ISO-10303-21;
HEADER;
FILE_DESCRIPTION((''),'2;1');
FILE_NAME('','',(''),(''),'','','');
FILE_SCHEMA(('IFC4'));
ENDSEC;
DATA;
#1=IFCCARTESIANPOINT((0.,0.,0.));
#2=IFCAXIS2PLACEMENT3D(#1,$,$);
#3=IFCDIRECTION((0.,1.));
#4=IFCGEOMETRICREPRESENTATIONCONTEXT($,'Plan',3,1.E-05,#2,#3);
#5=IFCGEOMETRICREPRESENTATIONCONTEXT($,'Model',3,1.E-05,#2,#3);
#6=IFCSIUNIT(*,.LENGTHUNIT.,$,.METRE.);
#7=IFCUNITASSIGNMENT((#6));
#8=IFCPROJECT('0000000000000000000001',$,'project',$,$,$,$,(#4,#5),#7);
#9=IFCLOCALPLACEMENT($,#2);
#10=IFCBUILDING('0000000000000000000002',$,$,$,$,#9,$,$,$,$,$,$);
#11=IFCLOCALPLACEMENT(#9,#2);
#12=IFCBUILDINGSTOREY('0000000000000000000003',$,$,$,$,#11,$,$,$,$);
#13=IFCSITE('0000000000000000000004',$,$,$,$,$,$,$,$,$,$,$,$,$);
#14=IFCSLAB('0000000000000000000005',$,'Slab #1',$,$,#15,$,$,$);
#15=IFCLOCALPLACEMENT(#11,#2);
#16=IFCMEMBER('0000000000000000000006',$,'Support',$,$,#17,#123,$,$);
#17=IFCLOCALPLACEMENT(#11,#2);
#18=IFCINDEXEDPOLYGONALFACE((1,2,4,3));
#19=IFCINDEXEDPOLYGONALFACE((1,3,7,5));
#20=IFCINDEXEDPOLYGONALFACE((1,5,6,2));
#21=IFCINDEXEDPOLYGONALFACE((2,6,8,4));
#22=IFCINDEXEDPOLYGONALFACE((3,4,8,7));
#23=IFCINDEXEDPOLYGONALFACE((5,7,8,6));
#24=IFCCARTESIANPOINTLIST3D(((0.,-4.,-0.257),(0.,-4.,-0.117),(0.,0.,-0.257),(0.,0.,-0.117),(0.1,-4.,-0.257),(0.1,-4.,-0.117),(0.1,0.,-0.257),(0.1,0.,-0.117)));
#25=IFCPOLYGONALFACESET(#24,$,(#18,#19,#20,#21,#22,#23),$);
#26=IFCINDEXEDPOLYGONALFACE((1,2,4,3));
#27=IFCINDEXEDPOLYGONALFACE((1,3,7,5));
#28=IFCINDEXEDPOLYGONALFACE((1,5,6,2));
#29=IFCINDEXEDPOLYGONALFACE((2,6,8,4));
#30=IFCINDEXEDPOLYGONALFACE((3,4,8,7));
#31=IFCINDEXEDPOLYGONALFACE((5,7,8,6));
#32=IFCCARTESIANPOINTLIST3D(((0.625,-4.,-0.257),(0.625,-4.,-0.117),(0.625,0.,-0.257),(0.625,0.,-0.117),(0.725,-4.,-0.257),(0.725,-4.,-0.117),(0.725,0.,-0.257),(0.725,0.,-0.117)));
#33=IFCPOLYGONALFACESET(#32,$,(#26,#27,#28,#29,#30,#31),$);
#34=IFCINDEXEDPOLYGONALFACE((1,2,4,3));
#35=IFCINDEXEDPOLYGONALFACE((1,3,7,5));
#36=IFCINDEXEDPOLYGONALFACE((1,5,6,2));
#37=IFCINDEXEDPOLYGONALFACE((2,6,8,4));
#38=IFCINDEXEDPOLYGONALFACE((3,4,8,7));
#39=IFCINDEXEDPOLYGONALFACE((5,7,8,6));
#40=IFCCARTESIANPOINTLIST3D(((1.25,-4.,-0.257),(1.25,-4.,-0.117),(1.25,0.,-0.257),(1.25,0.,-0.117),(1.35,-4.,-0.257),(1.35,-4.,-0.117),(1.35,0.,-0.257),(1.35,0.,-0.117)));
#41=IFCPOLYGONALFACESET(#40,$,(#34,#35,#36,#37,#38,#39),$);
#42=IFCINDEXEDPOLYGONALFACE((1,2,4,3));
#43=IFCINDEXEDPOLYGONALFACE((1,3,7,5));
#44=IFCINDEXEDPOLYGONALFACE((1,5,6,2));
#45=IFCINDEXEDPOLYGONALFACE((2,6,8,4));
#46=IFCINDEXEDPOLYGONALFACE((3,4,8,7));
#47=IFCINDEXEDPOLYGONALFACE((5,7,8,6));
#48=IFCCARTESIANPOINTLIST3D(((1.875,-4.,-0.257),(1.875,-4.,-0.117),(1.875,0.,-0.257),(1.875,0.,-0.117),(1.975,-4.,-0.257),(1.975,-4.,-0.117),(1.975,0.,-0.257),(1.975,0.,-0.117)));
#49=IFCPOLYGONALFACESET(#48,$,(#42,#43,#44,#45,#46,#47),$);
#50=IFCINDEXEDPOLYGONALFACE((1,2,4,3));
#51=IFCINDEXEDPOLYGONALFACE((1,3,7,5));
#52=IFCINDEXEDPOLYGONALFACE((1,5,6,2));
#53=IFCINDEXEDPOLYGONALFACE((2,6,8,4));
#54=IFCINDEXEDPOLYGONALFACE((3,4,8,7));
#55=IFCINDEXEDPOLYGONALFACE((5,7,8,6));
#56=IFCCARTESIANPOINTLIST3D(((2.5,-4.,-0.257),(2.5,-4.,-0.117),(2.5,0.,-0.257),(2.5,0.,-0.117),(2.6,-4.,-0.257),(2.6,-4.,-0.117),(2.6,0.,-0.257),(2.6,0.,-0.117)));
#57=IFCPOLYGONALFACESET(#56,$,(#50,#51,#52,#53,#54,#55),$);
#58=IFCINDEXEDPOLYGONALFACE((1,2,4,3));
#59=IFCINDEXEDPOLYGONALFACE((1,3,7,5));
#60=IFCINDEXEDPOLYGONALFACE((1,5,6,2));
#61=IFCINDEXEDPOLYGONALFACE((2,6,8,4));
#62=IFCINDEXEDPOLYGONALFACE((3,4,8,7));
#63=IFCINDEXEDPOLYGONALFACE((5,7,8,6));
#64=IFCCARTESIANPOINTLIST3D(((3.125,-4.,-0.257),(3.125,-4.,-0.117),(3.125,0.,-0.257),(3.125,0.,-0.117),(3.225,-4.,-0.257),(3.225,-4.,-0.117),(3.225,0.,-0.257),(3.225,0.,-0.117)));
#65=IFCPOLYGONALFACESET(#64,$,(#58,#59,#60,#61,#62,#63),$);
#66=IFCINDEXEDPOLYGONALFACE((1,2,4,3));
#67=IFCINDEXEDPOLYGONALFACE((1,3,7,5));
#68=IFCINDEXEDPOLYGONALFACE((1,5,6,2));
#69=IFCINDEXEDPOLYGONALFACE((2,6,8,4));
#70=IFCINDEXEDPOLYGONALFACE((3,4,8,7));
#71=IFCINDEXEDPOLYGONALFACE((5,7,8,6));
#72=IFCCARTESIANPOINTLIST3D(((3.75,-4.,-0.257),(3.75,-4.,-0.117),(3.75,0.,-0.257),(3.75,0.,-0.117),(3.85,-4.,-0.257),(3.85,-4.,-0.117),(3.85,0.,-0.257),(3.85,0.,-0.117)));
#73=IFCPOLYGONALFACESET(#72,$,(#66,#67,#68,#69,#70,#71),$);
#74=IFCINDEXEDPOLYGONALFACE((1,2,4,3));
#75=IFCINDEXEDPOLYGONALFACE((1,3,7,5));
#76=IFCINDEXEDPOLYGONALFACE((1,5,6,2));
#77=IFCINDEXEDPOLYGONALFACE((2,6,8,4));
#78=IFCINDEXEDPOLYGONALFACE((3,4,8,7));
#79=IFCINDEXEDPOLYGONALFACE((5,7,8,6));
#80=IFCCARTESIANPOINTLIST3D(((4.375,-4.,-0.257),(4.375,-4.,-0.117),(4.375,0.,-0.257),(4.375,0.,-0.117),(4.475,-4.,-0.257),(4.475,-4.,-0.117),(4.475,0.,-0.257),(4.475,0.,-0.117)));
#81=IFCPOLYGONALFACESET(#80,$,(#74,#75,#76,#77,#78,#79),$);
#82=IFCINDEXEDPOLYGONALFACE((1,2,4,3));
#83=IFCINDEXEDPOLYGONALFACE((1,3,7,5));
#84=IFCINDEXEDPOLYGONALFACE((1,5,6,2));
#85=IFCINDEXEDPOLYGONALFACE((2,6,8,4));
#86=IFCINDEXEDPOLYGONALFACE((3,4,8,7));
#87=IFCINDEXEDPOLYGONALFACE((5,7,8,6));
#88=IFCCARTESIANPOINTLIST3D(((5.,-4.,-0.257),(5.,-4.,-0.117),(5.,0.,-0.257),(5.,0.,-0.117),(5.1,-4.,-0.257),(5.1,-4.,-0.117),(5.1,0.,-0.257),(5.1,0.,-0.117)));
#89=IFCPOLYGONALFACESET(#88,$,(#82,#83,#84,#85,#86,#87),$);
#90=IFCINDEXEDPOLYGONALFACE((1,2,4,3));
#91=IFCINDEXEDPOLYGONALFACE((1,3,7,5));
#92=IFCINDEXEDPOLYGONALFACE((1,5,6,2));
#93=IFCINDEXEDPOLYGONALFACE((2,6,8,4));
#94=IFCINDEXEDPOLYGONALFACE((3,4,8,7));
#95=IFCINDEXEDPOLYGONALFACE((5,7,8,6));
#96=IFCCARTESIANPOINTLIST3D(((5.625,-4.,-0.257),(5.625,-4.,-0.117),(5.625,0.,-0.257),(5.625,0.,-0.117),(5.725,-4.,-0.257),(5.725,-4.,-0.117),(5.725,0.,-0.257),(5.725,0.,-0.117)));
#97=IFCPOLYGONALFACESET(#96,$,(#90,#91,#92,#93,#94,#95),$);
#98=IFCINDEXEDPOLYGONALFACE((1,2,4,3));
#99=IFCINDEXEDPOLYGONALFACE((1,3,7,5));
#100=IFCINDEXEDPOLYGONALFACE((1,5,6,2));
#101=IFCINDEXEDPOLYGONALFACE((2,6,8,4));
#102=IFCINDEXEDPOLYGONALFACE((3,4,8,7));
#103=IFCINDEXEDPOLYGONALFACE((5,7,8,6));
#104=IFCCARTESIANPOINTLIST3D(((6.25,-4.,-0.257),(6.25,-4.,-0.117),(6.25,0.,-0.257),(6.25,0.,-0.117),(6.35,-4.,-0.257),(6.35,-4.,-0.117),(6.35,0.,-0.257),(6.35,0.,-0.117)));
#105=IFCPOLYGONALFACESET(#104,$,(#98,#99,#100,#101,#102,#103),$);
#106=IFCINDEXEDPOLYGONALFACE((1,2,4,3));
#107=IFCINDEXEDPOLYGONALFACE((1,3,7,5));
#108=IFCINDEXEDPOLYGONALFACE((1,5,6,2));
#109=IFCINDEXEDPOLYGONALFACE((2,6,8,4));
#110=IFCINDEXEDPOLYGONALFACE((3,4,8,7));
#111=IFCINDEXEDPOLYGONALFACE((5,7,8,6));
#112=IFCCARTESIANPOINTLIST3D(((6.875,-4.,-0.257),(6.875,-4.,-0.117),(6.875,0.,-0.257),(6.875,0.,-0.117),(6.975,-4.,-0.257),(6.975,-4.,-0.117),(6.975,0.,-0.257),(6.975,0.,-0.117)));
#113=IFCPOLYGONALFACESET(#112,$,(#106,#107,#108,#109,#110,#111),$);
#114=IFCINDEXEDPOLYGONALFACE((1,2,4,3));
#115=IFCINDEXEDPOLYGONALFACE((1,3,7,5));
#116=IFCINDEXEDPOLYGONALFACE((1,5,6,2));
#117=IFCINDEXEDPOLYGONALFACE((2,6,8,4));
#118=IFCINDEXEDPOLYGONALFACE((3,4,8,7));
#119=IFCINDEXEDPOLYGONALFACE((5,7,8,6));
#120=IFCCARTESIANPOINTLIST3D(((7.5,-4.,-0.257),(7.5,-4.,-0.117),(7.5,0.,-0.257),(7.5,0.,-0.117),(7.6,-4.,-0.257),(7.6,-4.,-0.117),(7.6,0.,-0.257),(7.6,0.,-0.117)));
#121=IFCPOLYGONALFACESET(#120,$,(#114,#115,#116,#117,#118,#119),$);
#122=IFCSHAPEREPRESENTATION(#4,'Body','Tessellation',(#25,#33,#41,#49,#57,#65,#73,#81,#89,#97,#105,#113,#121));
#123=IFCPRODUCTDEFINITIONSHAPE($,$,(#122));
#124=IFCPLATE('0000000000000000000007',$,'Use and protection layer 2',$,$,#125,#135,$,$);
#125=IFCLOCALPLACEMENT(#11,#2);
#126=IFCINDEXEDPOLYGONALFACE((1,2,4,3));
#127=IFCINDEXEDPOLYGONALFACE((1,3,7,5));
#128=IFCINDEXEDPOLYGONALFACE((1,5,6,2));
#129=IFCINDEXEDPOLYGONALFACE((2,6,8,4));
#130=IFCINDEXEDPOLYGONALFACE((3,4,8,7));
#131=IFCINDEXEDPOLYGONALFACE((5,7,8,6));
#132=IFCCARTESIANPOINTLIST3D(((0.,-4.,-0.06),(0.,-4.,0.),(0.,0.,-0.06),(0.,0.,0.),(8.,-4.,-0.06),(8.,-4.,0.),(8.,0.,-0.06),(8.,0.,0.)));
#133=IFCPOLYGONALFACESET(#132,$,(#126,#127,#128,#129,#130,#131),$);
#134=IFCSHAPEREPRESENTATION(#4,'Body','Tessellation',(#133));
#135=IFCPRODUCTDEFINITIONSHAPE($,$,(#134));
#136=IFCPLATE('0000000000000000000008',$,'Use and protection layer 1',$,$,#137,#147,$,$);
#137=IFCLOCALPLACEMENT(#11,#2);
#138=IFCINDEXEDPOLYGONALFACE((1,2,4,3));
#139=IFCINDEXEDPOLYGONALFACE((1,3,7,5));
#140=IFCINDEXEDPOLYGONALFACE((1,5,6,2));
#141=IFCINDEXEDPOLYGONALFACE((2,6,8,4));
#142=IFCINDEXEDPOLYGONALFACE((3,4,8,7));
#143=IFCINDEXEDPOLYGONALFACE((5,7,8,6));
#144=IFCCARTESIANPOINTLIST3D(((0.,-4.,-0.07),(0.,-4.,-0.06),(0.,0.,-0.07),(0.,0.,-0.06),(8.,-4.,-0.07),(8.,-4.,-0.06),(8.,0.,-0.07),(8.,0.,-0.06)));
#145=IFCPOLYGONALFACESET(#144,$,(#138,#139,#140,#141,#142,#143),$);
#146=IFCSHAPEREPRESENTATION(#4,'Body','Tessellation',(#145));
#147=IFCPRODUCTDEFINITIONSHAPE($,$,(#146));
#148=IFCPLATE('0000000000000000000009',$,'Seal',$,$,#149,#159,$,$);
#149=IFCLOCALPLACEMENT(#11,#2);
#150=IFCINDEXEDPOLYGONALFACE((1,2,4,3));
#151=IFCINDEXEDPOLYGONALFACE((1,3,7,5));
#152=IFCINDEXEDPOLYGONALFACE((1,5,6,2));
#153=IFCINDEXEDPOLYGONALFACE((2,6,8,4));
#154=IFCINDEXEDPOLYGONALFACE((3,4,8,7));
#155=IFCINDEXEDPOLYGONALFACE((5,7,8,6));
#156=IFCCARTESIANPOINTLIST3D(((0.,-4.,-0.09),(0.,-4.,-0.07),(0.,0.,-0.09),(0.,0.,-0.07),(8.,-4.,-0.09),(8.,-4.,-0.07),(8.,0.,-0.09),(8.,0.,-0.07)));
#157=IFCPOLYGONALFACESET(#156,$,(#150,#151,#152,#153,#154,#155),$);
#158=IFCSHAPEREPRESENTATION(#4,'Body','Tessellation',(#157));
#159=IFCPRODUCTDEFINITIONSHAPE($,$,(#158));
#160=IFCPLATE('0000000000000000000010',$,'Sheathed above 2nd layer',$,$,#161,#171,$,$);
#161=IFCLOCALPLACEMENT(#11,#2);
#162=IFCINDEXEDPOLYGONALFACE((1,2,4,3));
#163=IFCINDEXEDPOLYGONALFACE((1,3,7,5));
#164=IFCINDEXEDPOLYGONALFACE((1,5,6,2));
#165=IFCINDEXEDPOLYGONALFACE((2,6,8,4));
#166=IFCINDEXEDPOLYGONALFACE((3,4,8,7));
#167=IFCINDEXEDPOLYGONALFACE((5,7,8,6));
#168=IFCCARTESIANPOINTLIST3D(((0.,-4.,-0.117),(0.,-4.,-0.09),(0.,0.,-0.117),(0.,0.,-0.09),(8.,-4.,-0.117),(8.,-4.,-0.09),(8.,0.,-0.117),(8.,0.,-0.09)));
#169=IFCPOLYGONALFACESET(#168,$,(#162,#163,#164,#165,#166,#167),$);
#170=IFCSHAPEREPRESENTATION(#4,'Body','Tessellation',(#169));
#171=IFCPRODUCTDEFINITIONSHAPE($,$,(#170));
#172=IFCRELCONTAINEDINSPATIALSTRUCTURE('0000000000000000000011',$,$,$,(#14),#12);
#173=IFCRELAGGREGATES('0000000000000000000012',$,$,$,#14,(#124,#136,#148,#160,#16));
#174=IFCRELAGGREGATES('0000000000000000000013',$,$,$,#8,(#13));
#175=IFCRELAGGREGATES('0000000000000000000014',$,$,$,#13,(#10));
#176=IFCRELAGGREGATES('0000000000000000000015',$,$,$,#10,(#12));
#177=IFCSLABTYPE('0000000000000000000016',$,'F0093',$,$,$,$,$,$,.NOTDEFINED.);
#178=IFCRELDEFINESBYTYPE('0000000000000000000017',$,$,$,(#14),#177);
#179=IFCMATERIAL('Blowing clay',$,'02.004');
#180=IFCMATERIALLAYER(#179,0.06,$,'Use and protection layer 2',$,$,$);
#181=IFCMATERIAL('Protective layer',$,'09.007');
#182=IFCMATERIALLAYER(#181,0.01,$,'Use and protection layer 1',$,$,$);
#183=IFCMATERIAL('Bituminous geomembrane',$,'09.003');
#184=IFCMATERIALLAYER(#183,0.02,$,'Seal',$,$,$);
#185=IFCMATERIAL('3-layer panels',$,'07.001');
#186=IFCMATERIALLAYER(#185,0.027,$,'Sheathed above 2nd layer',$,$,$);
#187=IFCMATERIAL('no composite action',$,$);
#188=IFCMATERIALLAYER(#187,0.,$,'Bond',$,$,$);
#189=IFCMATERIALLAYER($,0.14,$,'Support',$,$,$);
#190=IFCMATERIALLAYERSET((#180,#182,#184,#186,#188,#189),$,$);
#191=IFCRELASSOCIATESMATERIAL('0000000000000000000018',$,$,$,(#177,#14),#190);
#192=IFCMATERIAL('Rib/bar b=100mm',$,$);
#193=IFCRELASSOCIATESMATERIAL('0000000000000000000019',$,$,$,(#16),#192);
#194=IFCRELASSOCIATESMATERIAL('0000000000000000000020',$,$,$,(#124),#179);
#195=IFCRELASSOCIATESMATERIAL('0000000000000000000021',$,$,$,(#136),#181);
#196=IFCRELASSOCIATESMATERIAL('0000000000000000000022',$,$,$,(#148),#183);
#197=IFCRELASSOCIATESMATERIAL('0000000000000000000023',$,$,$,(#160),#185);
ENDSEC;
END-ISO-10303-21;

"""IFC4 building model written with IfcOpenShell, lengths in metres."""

from ifc_helpers import new_model, si_unit, direction, frame, frame_2d, origin, origin_with_axes, place, context, project, spatial, rectangle, extrude, material, layer, layer_set, type_object, element, aggregate, save


model = new_model("IFC4")

# Units and contexts
plan_context = context("Plan", 3, precision=1e-05, world=origin(), true_north=direction((0.0, 1.0)))
model_context = context("Model", 3, precision=1e-05, world=origin(), true_north=direction((0.0, 1.0)))
ifc_project = project(units=[si_unit("LENGTHUNIT", "METRE")], contexts=[plan_context, model_context])

# Site, building, storey
site = spatial("IfcSite", under=ifc_project)
building_placement = place(None, origin())
building = spatial("IfcBuilding", under=site, at=building_placement)
storey_placement = place(building_placement, origin())
storey = spatial("IfcBuildingStorey", under=building, at=storey_placement)

# Slab, member, plates
ifc_material_1 = material(Name="Blowing clay", Category="02.004")
ifc_layer_1 = layer(ifc_material_1, 0.06, Name="Use and protection layer 2")
ifc_material_2 = material(Name="Protective layer", Category="09.007")
ifc_layer_2 = layer(ifc_material_2, 0.01, Name="Use and protection layer 1")
ifc_material_3 = material(Name="Bituminous geomembrane", Category="09.003")
ifc_layer_3 = layer(ifc_material_3, 0.02, Name="Seal")
ifc_material_4 = material(Name="3-layer panels", Category="07.001")
ifc_layer_4 = layer(ifc_material_4, 0.027, Name="Sheathed above 2nd layer")
ifc_material_5 = material(Name="no composite action")
ifc_layer_5 = layer(ifc_material_5, 0.0, Name="Bond")
ifc_layer_6 = layer(None, 0.14, Name="Support")
ifc_layer_set = layer_set([ifc_layer_1, ifc_layer_2, ifc_layer_3, ifc_layer_4, ifc_layer_5, ifc_layer_6])
slab_type = type_object("IfcSlabType", Name="F0093", PredefinedType="NOTDEFINED", material=ifc_layer_set)
slab_placement = place(None, frame((0.0, 0.0, 0.0), z_axis=(0.0, 0.0, -1.0), x_axis=(1.0, 0.0, 0.0)))
slab = element("IfcSlab", 1, at=slab_placement, inside=storey, type_object=slab_type, material=ifc_layer_set, Name="Slab #1")
ifc_material_6 = material(Name="Rib/bar b=100mm")
member_placement = place(slab_placement, origin())
member = element("IfcMember", 2, at=member_placement, material=ifc_material_6, Name="Support", context=plan_context, shape_type="SweptSolid", body=[
    extrude(rectangle(XDim=0.1, YDim=0.14, at=frame_2d((0.05, 0.07), x_axis=(1.0, 0.0))), frame((0.0, 4.0, 0.117), z_axis=(0.0, -1.0, 0.0), x_axis=(1.0, 0.0, 0.0)), (0.0, 0.0, 1.0), 4.0),
    extrude(rectangle(XDim=0.1, YDim=0.14, at=frame_2d((0.05, 0.07), x_axis=(1.0, 0.0))), frame((0.625, 4.0, 0.117), z_axis=(0.0, -1.0, 0.0), x_axis=(1.0, 0.0, 0.0)), (0.0, 0.0, 1.0), 4.0),
    extrude(rectangle(XDim=0.1, YDim=0.14, at=frame_2d((0.05, 0.07), x_axis=(1.0, 0.0))), frame((1.25, 4.0, 0.117), z_axis=(0.0, -1.0, 0.0), x_axis=(1.0, 0.0, 0.0)), (0.0, 0.0, 1.0), 4.0),
    extrude(rectangle(XDim=0.1, YDim=0.14, at=frame_2d((0.05, 0.07), x_axis=(1.0, 0.0))), frame((1.875, 4.0, 0.117), z_axis=(0.0, -1.0, 0.0), x_axis=(1.0, 0.0, 0.0)), (0.0, 0.0, 1.0), 4.0),
    extrude(rectangle(XDim=0.1, YDim=0.14, at=frame_2d((0.05, 0.07), x_axis=(1.0, 0.0))), frame((2.5, 4.0, 0.117), z_axis=(0.0, -1.0, 0.0), x_axis=(1.0, 0.0, 0.0)), (0.0, 0.0, 1.0), 4.0),
    extrude(rectangle(XDim=0.1, YDim=0.14, at=frame_2d((0.05, 0.07), x_axis=(1.0, 0.0))), frame((3.125, 4.0, 0.117), z_axis=(0.0, -1.0, 0.0), x_axis=(1.0, 0.0, 0.0)), (0.0, 0.0, 1.0), 4.0),
    extrude(rectangle(XDim=0.1, YDim=0.14, at=frame_2d((0.05, 0.07), x_axis=(1.0, 0.0))), frame((3.75, 4.0, 0.117), z_axis=(0.0, -1.0, 0.0), x_axis=(1.0, 0.0, 0.0)), (0.0, 0.0, 1.0), 4.0),
    extrude(rectangle(XDim=0.1, YDim=0.14, at=frame_2d((0.05, 0.07), x_axis=(1.0, 0.0))), frame((4.375, 4.0, 0.117), z_axis=(0.0, -1.0, 0.0), x_axis=(1.0, 0.0, 0.0)), (0.0, 0.0, 1.0), 4.0),
    extrude(rectangle(XDim=0.1, YDim=0.14, at=frame_2d((0.05, 0.07), x_axis=(1.0, 0.0))), frame((5.0, 4.0, 0.117), z_axis=(0.0, -1.0, 0.0), x_axis=(1.0, 0.0, 0.0)), (0.0, 0.0, 1.0), 4.0),
    extrude(rectangle(XDim=0.1, YDim=0.14, at=frame_2d((0.05, 0.07), x_axis=(1.0, 0.0))), frame((5.625, 4.0, 0.117), z_axis=(0.0, -1.0, 0.0), x_axis=(1.0, 0.0, 0.0)), (0.0, 0.0, 1.0), 4.0),
    extrude(rectangle(XDim=0.1, YDim=0.14, at=frame_2d((0.05, 0.07), x_axis=(1.0, 0.0))), frame((6.25, 4.0, 0.117), z_axis=(0.0, -1.0, 0.0), x_axis=(1.0, 0.0, 0.0)), (0.0, 0.0, 1.0), 4.0),
    extrude(rectangle(XDim=0.1, YDim=0.14, at=frame_2d((0.05, 0.07), x_axis=(1.0, 0.0))), frame((6.875, 4.0, 0.117), z_axis=(0.0, -1.0, 0.0), x_axis=(1.0, 0.0, 0.0)), (0.0, 0.0, 1.0), 4.0),
    extrude(rectangle(XDim=0.1, YDim=0.14, at=frame_2d((0.05, 0.07), x_axis=(1.0, 0.0))), frame((7.5, 4.0, 0.117), z_axis=(0.0, -1.0, 0.0), x_axis=(1.0, 0.0, 0.0)), (0.0, 0.0, 1.0), 4.0),
])
plate_1_placement = place(slab_placement, origin())
plate_1 = element("IfcPlate", 3, at=plate_1_placement, material=ifc_material_1, Name="Use and protection layer 2", context=plan_context, shape_type="SweptSolid", body=[
    extrude(rectangle(XDim=8.0, YDim=4.0, at=frame_2d((4.0, 2.0), x_axis=(1.0, 0.0))), origin_with_axes(), (0.0, 0.0, 1.0), 0.06),
])
plate_2_placement = place(slab_placement, origin())
plate_2 = element("IfcPlate", 4, at=plate_2_placement, material=ifc_material_2, Name="Use and protection layer 1", context=plan_context, shape_type="SweptSolid", body=[
    extrude(rectangle(XDim=8.0, YDim=4.0, at=frame_2d((4.0, 2.0), x_axis=(1.0, 0.0))), frame((0.0, 0.0, 0.06), z_axis=(0.0, 0.0, 1.0), x_axis=(1.0, 0.0, 0.0)), (0.0, 0.0, 1.0), 0.01),
])
plate_3_placement = place(slab_placement, origin())
plate_3 = element("IfcPlate", 5, at=plate_3_placement, material=ifc_material_3, Name="Seal", context=plan_context, shape_type="SweptSolid", body=[
    extrude(rectangle(XDim=8.0, YDim=4.0, at=frame_2d((4.0, 2.0), x_axis=(1.0, 0.0))), frame((0.0, 0.0, 0.07), z_axis=(0.0, 0.0, 1.0), x_axis=(1.0, 0.0, 0.0)), (0.0, 0.0, 1.0), 0.02),
])
plate_4_placement = place(slab_placement, origin())
plate_4 = element("IfcPlate", 6, at=plate_4_placement, material=ifc_material_4, Name="Sheathed above 2nd layer", context=plan_context, shape_type="SweptSolid", body=[
    extrude(rectangle(XDim=8.0, YDim=4.0, at=frame_2d((4.0, 2.0), x_axis=(1.0, 0.0))), frame((0.0, 0.0, 0.09), z_axis=(0.0, 0.0, 1.0), x_axis=(1.0, 0.0, 0.0)), (0.0, 0.0, 1.0), 0.027),
])
aggregate(slab, [plate_1, plate_2, plate_3, plate_4, member])

save(model, "model.ifc")
